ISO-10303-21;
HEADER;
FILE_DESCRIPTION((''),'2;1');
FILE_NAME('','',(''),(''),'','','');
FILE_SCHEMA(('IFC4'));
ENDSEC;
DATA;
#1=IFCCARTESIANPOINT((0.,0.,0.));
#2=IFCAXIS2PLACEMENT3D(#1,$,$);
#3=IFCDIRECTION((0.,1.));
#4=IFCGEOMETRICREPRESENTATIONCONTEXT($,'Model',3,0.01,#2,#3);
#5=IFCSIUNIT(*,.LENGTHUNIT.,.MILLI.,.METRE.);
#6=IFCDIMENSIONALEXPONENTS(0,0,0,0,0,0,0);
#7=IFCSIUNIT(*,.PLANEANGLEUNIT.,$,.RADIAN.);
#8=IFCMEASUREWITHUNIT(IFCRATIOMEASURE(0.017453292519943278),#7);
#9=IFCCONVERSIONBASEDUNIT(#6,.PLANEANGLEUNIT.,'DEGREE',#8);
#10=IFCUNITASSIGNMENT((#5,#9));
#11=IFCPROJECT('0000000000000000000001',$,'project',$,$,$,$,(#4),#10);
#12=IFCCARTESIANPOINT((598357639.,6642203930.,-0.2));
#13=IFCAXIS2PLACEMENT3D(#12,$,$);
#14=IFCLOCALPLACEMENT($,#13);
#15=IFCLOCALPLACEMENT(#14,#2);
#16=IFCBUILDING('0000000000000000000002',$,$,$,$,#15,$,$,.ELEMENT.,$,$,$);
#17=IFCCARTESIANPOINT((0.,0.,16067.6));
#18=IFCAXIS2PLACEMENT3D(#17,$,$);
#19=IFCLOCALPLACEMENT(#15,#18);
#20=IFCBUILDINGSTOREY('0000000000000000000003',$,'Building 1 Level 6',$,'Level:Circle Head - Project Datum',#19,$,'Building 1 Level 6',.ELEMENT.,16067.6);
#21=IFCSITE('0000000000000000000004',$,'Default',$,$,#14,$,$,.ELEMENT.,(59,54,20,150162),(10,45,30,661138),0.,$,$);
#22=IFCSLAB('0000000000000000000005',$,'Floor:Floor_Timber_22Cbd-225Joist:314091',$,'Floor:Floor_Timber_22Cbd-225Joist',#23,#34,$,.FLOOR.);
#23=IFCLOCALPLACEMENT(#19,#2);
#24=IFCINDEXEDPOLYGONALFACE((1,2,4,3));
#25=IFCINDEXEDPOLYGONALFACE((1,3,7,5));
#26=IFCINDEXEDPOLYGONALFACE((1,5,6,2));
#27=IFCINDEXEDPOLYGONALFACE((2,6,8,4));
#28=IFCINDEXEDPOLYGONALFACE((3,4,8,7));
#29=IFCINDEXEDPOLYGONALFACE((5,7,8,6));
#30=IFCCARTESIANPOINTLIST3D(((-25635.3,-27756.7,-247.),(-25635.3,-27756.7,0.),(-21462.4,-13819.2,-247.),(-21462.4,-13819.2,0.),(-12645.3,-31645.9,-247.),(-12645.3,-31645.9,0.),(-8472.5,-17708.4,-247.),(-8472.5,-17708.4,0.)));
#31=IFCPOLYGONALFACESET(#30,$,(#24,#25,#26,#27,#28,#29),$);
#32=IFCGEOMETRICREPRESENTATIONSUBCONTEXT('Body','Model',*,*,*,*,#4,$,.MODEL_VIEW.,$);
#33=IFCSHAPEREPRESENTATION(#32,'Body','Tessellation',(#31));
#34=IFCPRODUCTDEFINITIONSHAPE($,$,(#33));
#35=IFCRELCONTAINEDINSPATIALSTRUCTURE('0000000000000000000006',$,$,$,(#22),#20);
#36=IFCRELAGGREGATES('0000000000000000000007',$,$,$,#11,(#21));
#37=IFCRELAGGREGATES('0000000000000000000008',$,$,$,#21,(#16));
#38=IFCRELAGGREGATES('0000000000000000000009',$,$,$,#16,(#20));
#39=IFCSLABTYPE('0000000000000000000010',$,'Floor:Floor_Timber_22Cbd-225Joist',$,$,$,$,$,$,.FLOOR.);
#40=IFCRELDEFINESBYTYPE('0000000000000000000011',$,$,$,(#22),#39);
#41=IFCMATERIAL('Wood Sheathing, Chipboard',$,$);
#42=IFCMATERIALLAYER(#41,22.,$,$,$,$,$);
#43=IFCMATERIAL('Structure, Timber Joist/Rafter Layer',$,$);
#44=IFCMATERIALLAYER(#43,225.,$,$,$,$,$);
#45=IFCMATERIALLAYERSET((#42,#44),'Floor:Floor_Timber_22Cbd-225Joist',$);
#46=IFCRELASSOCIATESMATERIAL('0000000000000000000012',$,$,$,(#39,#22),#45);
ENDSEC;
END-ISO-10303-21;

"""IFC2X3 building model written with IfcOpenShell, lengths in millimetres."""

from ifc_helpers import new_model, entity, si_unit, converted_unit, direction, frame, frame_2d, origin, place, context, subcontext, project, spatial, rectangle, extrude, material, layer, layer_set, layer_usage, type_object, element, save


model = new_model("IFC2X3")

# Units and contexts
model_context = context("Model", 3, precision=0.01, world=origin(), true_north=direction((0.0, 1.0)))
body_context = subcontext(model_context, "Body", "Model", "MODEL_VIEW")
ifc_project = project(units=[si_unit("LENGTHUNIT", "METRE", prefix="MILLI"), converted_unit("PLANEANGLEUNIT", "DEGREE", entity("IfcRatioMeasure", 0.017453292519943278), si_unit("PLANEANGLEUNIT", "RADIAN"), dimensions=[0, 0, 0, 0, 0, 0, 0])], contexts=[model_context])

# Site, building, storey
site_placement = place(None, frame((598357639.0, 6642203930.0, -0.2)))
site = spatial("IfcSite", under=ifc_project, at=site_placement, Name="Default", CompositionType="ELEMENT", RefLatitude=(59, 54, 20, 150162), RefLongitude=(10, 45, 30, 661138), RefElevation=0.0)
building_placement = place(site_placement, origin())
building = spatial("IfcBuilding", under=site, at=building_placement, CompositionType="ELEMENT")
storey_placement = place(building_placement, frame((0.0, 0.0, 16067.6)))
storey = spatial("IfcBuildingStorey", under=building, at=storey_placement, Name="Building 1 Level 6", ObjectType="Level:Circle Head - Project Datum", LongName="Building 1 Level 6", CompositionType="ELEMENT", Elevation=16067.6)

# Slab
ifc_material_1 = material(Name="Wood Sheathing, Chipboard")
ifc_layer_1 = layer(ifc_material_1, 22.0)
ifc_material_2 = material(Name="Structure, Timber Joist/Rafter Layer")
ifc_layer_2 = layer(ifc_material_2, 225.0)
ifc_layer_set = layer_set([ifc_layer_1, ifc_layer_2], Name="Floor:Floor_Timber_22Cbd-225Joist")
ifc_layer_usage = layer_usage(ifc_layer_set, "AXIS3", "POSITIVE", 0.0)
slab_type = type_object("IfcSlabType", Name="Floor:Floor_Timber_22Cbd-225Joist", PredefinedType="FLOOR", material=ifc_layer_set)
slab_placement = place(storey_placement, origin())
element("IfcSlab", 1, at=slab_placement, inside=storey, type_object=slab_type, material=ifc_layer_usage, Name="Floor:Floor_Timber_22Cbd-225Joist:314091", ObjectType="Floor:Floor_Timber_22Cbd-225Joist", PredefinedType="FLOOR", context=body_context, shape_type="SweptSolid", body=[
    extrude(rectangle(XDim=14548.8, YDim=13559.7, at=frame_2d((0.0, 0.0), x_axis=(1.0, 0.0))), frame((-17053.9, -22732.6, 0.0), z_axis=(0.0, 0.0, -1.0), x_axis=(-0.286817, -0.957985, 0.0)), (0.0, 0.0, 1.0), 247.0),
])

save(model, "model.ifc")
